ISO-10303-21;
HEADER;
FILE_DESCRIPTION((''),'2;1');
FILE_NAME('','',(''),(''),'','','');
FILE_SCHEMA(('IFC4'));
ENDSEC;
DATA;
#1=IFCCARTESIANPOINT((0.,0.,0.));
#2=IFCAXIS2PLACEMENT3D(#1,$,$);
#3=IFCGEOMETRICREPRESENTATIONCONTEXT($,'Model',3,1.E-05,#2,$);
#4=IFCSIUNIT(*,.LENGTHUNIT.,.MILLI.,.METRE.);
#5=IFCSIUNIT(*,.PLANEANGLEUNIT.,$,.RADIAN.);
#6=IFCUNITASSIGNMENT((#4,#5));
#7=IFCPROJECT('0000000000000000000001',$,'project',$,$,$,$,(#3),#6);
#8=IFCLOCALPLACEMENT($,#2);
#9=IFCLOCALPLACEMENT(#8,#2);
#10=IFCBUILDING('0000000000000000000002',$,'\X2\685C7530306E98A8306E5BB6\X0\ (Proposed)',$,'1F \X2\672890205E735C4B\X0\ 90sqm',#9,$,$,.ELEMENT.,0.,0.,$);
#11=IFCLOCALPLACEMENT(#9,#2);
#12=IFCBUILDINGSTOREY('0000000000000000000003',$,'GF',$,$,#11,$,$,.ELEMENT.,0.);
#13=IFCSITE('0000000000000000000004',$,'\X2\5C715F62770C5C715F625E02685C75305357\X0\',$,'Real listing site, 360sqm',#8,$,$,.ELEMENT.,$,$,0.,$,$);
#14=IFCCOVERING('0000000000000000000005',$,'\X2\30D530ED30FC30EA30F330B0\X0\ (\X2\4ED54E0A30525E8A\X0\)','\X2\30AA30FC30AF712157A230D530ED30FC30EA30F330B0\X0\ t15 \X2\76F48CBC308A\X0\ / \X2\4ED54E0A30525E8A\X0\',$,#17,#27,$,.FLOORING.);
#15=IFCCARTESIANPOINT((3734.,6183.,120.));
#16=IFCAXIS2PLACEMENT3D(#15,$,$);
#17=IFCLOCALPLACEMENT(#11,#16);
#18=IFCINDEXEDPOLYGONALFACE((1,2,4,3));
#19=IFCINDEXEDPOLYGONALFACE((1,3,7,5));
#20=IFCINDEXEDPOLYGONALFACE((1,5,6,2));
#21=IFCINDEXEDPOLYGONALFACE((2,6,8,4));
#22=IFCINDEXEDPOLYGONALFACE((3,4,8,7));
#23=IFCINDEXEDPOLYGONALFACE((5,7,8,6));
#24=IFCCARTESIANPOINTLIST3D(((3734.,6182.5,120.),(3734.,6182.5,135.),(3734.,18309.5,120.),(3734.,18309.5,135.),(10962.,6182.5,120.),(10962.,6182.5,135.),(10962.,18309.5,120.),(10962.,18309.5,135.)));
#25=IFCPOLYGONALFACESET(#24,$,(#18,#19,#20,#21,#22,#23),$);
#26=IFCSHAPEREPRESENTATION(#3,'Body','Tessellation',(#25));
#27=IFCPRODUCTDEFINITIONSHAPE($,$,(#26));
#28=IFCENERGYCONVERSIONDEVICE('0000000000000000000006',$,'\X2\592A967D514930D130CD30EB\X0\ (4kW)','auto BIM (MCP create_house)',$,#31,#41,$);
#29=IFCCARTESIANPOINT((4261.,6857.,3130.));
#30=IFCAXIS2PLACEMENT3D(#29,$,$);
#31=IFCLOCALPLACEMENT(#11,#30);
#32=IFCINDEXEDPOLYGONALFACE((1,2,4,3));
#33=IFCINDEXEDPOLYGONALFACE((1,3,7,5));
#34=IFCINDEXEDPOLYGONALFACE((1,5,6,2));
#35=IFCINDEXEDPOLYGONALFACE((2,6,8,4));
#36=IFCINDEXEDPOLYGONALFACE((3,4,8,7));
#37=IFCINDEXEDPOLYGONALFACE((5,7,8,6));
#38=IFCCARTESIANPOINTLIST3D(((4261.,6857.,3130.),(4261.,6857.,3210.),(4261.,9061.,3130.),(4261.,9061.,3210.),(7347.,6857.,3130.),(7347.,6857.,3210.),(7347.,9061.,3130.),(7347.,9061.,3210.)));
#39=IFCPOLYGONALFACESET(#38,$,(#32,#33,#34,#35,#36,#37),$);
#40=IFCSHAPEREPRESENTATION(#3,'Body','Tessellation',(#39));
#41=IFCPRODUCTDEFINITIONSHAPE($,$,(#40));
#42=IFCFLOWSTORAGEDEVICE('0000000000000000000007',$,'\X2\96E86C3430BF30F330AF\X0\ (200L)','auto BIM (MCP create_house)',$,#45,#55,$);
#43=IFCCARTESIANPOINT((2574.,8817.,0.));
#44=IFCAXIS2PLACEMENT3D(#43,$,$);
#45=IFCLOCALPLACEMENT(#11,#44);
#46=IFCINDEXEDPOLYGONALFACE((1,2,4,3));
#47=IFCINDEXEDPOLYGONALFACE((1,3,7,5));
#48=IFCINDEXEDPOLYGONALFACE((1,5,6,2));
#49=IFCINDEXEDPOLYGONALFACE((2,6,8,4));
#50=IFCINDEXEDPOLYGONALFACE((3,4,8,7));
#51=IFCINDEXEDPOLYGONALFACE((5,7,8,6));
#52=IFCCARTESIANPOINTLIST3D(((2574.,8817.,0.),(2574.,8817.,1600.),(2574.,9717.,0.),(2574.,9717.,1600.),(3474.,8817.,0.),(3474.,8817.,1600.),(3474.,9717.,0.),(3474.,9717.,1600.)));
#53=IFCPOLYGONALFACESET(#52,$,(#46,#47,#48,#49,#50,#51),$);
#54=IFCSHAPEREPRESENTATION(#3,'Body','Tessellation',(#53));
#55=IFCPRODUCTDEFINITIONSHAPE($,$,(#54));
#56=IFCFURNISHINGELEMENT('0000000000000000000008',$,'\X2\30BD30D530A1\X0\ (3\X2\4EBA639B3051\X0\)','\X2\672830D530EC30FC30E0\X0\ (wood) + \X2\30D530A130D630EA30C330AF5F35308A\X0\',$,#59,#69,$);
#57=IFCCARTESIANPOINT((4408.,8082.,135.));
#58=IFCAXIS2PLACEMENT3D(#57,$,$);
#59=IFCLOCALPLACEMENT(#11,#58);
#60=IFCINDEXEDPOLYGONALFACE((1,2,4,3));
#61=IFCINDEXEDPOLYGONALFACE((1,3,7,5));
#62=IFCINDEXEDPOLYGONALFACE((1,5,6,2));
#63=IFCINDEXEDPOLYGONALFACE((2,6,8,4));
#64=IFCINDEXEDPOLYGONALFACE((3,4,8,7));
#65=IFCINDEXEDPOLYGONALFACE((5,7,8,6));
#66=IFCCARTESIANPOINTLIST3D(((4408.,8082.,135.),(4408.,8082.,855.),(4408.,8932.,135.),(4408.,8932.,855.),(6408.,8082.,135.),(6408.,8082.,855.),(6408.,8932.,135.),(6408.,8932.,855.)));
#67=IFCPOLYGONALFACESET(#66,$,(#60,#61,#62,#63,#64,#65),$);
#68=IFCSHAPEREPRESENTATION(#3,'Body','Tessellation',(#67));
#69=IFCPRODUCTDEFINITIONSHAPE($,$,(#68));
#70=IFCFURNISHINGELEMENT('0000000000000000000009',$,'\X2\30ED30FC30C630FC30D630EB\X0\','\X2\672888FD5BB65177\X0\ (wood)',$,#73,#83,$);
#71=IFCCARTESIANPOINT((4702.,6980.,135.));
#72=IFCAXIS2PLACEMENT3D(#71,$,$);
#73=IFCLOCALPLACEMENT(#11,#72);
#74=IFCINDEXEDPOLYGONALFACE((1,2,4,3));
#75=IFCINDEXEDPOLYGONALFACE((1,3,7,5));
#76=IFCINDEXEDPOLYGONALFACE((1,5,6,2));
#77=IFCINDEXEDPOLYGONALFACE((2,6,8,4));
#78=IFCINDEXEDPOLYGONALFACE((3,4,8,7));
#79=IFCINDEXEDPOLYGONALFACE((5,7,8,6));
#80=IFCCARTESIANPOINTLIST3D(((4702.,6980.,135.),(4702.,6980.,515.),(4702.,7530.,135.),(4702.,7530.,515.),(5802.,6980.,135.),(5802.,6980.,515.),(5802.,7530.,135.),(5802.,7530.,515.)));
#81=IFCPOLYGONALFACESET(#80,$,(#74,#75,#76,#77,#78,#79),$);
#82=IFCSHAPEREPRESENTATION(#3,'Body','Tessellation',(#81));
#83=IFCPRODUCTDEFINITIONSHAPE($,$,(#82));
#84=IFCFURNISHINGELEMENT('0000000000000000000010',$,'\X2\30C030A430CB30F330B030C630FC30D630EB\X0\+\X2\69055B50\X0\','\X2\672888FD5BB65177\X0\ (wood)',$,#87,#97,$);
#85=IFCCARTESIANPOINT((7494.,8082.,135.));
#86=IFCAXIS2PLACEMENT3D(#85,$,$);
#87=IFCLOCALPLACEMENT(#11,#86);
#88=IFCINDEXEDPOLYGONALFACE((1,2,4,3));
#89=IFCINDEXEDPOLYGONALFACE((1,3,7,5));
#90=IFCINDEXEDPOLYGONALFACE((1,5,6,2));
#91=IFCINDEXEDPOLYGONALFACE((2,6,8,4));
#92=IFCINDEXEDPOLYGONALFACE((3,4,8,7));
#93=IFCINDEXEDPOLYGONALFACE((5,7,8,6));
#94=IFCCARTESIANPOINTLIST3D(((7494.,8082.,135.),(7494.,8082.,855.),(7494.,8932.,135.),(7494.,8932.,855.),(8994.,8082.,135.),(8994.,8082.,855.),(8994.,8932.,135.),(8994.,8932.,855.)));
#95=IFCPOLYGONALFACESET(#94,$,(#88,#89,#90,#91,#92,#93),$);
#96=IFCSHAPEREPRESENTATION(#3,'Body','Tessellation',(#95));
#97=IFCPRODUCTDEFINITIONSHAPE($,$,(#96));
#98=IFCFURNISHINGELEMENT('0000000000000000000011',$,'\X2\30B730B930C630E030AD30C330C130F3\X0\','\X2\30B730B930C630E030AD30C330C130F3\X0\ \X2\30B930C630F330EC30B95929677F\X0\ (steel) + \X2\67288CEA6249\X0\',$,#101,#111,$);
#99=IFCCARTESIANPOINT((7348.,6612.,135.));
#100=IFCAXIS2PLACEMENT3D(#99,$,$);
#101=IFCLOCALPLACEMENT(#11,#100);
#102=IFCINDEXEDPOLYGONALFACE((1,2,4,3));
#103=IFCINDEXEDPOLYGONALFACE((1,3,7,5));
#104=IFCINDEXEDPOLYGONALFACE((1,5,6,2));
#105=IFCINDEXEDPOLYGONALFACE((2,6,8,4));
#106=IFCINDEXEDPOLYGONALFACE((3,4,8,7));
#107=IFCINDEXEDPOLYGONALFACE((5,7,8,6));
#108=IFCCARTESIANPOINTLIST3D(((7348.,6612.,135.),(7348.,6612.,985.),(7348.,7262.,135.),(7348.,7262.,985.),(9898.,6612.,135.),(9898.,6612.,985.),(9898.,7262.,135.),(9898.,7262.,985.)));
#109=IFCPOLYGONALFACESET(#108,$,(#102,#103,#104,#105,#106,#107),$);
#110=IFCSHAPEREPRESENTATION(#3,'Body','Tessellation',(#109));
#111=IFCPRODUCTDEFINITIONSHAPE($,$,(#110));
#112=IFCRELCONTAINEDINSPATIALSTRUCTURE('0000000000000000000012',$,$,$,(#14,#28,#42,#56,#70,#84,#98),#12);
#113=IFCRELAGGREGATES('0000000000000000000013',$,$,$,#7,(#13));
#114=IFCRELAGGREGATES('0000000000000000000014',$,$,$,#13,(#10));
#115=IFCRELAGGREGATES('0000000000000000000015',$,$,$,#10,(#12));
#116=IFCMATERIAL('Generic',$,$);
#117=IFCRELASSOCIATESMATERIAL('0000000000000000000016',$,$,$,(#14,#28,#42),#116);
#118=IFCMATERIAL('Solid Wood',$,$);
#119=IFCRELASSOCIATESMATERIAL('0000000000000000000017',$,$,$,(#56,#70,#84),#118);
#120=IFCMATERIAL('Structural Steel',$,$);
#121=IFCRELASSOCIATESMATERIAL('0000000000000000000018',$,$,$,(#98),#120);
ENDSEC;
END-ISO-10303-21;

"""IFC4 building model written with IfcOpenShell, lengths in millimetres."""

from ifc_helpers import new_model, si_unit, frame, frame_2d, origin, place, context, project, spatial, rectangle, extrude, material, element, save


model = new_model("IFC4")

# Units and contexts
model_context = context("Model", 3, precision=1e-05, world=origin())
ifc_project = project(units=[si_unit("LENGTHUNIT", "METRE", prefix="MILLI"), si_unit("PLANEANGLEUNIT", "RADIAN")], contexts=[model_context])

# Site, building, storey
site_placement = place(None, origin())
site = spatial("IfcSite", under=ifc_project, at=site_placement, Name="山形県山形市桜田南", ObjectType="Real listing site, 360sqm", CompositionType="ELEMENT", RefElevation=0.0)
building_placement = place(site_placement, origin())
building = spatial("IfcBuilding", under=site, at=building_placement, Name="桜田の風の家 (Proposed)", ObjectType="1F 木造平屋 90sqm", CompositionType="ELEMENT", ElevationOfRefHeight=0.0, ElevationOfTerrain=0.0)
storey_placement = place(building_placement, origin())
storey = spatial("IfcBuildingStorey", under=building, at=storey_placement, Name="GF", CompositionType="ELEMENT", Elevation=0.0)

# Shared definitions
ifc_material_1 = material(Name="Solid Wood")

# Shared definitions
ifc_material_2 = material(Name="Structural Steel")

# Covering
ifc_material_3 = material(Name="Generic")
covering_placement = place(storey_placement, frame((3734.0, 6183.0, 120.0)))
element("IfcCovering", 1, at=covering_placement, inside=storey, material=ifc_material_3, Name="フローリング (仕上げ床)", Description="オーク無垢フローリング t15 直貼り / 仕上げ床", PredefinedType="FLOORING", context=model_context, shape_type="SweptSolid", body=[
    extrude(rectangle(XDim=7228.0, YDim=12127.0, at=frame_2d((3614.0, 6063.0))), frame((3734.0, 6183.0, 120.0)), (0.0, 0.0, 1.0), 15.0),
])

# Energy conversion device
energy_conversion_device_placement = place(storey_placement, frame((4261.0, 6857.0, 3130.0)))
element("IfcEnergyConversionDevice", 2, at=energy_conversion_device_placement, inside=storey, material=ifc_material_3, Name="太陽光パネル (4kW)", Description="auto BIM (MCP create_house)", context=model_context, shape_type="SweptSolid", body=[
    extrude(rectangle(XDim=3086.0, YDim=2204.0, at=frame_2d((1543.0, 1102.0))), frame((4261.0, 6857.0, 3130.0)), (0.0, 0.0, 1.0), 80.0),
])

# Flow storage device
flow_storage_device_placement = place(storey_placement, frame((2574.0, 8817.0, 0.0)))
element("IfcFlowStorageDevice", 3, at=flow_storage_device_placement, inside=storey, material=ifc_material_3, Name="雨水タンク (200L)", Description="auto BIM (MCP create_house)", context=model_context, shape_type="SweptSolid", body=[
    extrude(rectangle(XDim=900.0, YDim=900.0, at=frame_2d((450.0, 450.0))), frame((2574.0, 8817.0, 0.0)), (0.0, 0.0, 1.0), 1600.0),
])

# Furnishing elements
furnishing_1_placement = place(storey_placement, frame((4408.0, 8082.0, 135.0)))
element("IfcFurnishingElement", 4, at=furnishing_1_placement, inside=storey, material=ifc_material_1, Name="ソファ (3人掛け)", Description="木フレーム (wood) + ファブリック張り", context=model_context, shape_type="SweptSolid", body=[
    extrude(rectangle(XDim=2000.0, YDim=850.0, at=frame_2d((1000.0, 425.0))), frame((4408.0, 8082.0, 135.0)), (0.0, 0.0, 1.0), 720.0),
])
furnishing_2_placement = place(storey_placement, frame((4702.0, 6980.0, 135.0)))
element("IfcFurnishingElement", 5, at=furnishing_2_placement, inside=storey, material=ifc_material_1, Name="ローテーブル", Description="木製家具 (wood)", context=model_context, shape_type="SweptSolid", body=[
    extrude(rectangle(XDim=1100.0, YDim=550.0, at=frame_2d((550.0, 275.0))), frame((4702.0, 6980.0, 135.0)), (0.0, 0.0, 1.0), 380.0),
])
furnishing_3_placement = place(storey_placement, frame((7494.0, 8082.0, 135.0)))
element("IfcFurnishingElement", 6, at=furnishing_3_placement, inside=storey, material=ifc_material_1, Name="ダイニングテーブル+椅子", Description="木製家具 (wood)", context=model_context, shape_type="SweptSolid", body=[
    extrude(rectangle(XDim=1500.0, YDim=850.0, at=frame_2d((750.0, 425.0))), frame((7494.0, 8082.0, 135.0)), (0.0, 0.0, 1.0), 720.0),
])
furnishing_4_placement = place(storey_placement, frame((7348.0, 6612.0, 135.0)))
element("IfcFurnishingElement", 7, at=furnishing_4_placement, inside=storey, material=ifc_material_2, Name="システムキッチン", Description="システムキッチン ステンレス天板 (steel) + 木質扉", context=model_context, shape_type="SweptSolid", body=[
    extrude(rectangle(XDim=2550.0, YDim=650.0, at=frame_2d((1275.0, 325.0))), frame((7348.0, 6612.0, 135.0)), (0.0, 0.0, 1.0), 850.0),
])

save(model, "model.ifc")
